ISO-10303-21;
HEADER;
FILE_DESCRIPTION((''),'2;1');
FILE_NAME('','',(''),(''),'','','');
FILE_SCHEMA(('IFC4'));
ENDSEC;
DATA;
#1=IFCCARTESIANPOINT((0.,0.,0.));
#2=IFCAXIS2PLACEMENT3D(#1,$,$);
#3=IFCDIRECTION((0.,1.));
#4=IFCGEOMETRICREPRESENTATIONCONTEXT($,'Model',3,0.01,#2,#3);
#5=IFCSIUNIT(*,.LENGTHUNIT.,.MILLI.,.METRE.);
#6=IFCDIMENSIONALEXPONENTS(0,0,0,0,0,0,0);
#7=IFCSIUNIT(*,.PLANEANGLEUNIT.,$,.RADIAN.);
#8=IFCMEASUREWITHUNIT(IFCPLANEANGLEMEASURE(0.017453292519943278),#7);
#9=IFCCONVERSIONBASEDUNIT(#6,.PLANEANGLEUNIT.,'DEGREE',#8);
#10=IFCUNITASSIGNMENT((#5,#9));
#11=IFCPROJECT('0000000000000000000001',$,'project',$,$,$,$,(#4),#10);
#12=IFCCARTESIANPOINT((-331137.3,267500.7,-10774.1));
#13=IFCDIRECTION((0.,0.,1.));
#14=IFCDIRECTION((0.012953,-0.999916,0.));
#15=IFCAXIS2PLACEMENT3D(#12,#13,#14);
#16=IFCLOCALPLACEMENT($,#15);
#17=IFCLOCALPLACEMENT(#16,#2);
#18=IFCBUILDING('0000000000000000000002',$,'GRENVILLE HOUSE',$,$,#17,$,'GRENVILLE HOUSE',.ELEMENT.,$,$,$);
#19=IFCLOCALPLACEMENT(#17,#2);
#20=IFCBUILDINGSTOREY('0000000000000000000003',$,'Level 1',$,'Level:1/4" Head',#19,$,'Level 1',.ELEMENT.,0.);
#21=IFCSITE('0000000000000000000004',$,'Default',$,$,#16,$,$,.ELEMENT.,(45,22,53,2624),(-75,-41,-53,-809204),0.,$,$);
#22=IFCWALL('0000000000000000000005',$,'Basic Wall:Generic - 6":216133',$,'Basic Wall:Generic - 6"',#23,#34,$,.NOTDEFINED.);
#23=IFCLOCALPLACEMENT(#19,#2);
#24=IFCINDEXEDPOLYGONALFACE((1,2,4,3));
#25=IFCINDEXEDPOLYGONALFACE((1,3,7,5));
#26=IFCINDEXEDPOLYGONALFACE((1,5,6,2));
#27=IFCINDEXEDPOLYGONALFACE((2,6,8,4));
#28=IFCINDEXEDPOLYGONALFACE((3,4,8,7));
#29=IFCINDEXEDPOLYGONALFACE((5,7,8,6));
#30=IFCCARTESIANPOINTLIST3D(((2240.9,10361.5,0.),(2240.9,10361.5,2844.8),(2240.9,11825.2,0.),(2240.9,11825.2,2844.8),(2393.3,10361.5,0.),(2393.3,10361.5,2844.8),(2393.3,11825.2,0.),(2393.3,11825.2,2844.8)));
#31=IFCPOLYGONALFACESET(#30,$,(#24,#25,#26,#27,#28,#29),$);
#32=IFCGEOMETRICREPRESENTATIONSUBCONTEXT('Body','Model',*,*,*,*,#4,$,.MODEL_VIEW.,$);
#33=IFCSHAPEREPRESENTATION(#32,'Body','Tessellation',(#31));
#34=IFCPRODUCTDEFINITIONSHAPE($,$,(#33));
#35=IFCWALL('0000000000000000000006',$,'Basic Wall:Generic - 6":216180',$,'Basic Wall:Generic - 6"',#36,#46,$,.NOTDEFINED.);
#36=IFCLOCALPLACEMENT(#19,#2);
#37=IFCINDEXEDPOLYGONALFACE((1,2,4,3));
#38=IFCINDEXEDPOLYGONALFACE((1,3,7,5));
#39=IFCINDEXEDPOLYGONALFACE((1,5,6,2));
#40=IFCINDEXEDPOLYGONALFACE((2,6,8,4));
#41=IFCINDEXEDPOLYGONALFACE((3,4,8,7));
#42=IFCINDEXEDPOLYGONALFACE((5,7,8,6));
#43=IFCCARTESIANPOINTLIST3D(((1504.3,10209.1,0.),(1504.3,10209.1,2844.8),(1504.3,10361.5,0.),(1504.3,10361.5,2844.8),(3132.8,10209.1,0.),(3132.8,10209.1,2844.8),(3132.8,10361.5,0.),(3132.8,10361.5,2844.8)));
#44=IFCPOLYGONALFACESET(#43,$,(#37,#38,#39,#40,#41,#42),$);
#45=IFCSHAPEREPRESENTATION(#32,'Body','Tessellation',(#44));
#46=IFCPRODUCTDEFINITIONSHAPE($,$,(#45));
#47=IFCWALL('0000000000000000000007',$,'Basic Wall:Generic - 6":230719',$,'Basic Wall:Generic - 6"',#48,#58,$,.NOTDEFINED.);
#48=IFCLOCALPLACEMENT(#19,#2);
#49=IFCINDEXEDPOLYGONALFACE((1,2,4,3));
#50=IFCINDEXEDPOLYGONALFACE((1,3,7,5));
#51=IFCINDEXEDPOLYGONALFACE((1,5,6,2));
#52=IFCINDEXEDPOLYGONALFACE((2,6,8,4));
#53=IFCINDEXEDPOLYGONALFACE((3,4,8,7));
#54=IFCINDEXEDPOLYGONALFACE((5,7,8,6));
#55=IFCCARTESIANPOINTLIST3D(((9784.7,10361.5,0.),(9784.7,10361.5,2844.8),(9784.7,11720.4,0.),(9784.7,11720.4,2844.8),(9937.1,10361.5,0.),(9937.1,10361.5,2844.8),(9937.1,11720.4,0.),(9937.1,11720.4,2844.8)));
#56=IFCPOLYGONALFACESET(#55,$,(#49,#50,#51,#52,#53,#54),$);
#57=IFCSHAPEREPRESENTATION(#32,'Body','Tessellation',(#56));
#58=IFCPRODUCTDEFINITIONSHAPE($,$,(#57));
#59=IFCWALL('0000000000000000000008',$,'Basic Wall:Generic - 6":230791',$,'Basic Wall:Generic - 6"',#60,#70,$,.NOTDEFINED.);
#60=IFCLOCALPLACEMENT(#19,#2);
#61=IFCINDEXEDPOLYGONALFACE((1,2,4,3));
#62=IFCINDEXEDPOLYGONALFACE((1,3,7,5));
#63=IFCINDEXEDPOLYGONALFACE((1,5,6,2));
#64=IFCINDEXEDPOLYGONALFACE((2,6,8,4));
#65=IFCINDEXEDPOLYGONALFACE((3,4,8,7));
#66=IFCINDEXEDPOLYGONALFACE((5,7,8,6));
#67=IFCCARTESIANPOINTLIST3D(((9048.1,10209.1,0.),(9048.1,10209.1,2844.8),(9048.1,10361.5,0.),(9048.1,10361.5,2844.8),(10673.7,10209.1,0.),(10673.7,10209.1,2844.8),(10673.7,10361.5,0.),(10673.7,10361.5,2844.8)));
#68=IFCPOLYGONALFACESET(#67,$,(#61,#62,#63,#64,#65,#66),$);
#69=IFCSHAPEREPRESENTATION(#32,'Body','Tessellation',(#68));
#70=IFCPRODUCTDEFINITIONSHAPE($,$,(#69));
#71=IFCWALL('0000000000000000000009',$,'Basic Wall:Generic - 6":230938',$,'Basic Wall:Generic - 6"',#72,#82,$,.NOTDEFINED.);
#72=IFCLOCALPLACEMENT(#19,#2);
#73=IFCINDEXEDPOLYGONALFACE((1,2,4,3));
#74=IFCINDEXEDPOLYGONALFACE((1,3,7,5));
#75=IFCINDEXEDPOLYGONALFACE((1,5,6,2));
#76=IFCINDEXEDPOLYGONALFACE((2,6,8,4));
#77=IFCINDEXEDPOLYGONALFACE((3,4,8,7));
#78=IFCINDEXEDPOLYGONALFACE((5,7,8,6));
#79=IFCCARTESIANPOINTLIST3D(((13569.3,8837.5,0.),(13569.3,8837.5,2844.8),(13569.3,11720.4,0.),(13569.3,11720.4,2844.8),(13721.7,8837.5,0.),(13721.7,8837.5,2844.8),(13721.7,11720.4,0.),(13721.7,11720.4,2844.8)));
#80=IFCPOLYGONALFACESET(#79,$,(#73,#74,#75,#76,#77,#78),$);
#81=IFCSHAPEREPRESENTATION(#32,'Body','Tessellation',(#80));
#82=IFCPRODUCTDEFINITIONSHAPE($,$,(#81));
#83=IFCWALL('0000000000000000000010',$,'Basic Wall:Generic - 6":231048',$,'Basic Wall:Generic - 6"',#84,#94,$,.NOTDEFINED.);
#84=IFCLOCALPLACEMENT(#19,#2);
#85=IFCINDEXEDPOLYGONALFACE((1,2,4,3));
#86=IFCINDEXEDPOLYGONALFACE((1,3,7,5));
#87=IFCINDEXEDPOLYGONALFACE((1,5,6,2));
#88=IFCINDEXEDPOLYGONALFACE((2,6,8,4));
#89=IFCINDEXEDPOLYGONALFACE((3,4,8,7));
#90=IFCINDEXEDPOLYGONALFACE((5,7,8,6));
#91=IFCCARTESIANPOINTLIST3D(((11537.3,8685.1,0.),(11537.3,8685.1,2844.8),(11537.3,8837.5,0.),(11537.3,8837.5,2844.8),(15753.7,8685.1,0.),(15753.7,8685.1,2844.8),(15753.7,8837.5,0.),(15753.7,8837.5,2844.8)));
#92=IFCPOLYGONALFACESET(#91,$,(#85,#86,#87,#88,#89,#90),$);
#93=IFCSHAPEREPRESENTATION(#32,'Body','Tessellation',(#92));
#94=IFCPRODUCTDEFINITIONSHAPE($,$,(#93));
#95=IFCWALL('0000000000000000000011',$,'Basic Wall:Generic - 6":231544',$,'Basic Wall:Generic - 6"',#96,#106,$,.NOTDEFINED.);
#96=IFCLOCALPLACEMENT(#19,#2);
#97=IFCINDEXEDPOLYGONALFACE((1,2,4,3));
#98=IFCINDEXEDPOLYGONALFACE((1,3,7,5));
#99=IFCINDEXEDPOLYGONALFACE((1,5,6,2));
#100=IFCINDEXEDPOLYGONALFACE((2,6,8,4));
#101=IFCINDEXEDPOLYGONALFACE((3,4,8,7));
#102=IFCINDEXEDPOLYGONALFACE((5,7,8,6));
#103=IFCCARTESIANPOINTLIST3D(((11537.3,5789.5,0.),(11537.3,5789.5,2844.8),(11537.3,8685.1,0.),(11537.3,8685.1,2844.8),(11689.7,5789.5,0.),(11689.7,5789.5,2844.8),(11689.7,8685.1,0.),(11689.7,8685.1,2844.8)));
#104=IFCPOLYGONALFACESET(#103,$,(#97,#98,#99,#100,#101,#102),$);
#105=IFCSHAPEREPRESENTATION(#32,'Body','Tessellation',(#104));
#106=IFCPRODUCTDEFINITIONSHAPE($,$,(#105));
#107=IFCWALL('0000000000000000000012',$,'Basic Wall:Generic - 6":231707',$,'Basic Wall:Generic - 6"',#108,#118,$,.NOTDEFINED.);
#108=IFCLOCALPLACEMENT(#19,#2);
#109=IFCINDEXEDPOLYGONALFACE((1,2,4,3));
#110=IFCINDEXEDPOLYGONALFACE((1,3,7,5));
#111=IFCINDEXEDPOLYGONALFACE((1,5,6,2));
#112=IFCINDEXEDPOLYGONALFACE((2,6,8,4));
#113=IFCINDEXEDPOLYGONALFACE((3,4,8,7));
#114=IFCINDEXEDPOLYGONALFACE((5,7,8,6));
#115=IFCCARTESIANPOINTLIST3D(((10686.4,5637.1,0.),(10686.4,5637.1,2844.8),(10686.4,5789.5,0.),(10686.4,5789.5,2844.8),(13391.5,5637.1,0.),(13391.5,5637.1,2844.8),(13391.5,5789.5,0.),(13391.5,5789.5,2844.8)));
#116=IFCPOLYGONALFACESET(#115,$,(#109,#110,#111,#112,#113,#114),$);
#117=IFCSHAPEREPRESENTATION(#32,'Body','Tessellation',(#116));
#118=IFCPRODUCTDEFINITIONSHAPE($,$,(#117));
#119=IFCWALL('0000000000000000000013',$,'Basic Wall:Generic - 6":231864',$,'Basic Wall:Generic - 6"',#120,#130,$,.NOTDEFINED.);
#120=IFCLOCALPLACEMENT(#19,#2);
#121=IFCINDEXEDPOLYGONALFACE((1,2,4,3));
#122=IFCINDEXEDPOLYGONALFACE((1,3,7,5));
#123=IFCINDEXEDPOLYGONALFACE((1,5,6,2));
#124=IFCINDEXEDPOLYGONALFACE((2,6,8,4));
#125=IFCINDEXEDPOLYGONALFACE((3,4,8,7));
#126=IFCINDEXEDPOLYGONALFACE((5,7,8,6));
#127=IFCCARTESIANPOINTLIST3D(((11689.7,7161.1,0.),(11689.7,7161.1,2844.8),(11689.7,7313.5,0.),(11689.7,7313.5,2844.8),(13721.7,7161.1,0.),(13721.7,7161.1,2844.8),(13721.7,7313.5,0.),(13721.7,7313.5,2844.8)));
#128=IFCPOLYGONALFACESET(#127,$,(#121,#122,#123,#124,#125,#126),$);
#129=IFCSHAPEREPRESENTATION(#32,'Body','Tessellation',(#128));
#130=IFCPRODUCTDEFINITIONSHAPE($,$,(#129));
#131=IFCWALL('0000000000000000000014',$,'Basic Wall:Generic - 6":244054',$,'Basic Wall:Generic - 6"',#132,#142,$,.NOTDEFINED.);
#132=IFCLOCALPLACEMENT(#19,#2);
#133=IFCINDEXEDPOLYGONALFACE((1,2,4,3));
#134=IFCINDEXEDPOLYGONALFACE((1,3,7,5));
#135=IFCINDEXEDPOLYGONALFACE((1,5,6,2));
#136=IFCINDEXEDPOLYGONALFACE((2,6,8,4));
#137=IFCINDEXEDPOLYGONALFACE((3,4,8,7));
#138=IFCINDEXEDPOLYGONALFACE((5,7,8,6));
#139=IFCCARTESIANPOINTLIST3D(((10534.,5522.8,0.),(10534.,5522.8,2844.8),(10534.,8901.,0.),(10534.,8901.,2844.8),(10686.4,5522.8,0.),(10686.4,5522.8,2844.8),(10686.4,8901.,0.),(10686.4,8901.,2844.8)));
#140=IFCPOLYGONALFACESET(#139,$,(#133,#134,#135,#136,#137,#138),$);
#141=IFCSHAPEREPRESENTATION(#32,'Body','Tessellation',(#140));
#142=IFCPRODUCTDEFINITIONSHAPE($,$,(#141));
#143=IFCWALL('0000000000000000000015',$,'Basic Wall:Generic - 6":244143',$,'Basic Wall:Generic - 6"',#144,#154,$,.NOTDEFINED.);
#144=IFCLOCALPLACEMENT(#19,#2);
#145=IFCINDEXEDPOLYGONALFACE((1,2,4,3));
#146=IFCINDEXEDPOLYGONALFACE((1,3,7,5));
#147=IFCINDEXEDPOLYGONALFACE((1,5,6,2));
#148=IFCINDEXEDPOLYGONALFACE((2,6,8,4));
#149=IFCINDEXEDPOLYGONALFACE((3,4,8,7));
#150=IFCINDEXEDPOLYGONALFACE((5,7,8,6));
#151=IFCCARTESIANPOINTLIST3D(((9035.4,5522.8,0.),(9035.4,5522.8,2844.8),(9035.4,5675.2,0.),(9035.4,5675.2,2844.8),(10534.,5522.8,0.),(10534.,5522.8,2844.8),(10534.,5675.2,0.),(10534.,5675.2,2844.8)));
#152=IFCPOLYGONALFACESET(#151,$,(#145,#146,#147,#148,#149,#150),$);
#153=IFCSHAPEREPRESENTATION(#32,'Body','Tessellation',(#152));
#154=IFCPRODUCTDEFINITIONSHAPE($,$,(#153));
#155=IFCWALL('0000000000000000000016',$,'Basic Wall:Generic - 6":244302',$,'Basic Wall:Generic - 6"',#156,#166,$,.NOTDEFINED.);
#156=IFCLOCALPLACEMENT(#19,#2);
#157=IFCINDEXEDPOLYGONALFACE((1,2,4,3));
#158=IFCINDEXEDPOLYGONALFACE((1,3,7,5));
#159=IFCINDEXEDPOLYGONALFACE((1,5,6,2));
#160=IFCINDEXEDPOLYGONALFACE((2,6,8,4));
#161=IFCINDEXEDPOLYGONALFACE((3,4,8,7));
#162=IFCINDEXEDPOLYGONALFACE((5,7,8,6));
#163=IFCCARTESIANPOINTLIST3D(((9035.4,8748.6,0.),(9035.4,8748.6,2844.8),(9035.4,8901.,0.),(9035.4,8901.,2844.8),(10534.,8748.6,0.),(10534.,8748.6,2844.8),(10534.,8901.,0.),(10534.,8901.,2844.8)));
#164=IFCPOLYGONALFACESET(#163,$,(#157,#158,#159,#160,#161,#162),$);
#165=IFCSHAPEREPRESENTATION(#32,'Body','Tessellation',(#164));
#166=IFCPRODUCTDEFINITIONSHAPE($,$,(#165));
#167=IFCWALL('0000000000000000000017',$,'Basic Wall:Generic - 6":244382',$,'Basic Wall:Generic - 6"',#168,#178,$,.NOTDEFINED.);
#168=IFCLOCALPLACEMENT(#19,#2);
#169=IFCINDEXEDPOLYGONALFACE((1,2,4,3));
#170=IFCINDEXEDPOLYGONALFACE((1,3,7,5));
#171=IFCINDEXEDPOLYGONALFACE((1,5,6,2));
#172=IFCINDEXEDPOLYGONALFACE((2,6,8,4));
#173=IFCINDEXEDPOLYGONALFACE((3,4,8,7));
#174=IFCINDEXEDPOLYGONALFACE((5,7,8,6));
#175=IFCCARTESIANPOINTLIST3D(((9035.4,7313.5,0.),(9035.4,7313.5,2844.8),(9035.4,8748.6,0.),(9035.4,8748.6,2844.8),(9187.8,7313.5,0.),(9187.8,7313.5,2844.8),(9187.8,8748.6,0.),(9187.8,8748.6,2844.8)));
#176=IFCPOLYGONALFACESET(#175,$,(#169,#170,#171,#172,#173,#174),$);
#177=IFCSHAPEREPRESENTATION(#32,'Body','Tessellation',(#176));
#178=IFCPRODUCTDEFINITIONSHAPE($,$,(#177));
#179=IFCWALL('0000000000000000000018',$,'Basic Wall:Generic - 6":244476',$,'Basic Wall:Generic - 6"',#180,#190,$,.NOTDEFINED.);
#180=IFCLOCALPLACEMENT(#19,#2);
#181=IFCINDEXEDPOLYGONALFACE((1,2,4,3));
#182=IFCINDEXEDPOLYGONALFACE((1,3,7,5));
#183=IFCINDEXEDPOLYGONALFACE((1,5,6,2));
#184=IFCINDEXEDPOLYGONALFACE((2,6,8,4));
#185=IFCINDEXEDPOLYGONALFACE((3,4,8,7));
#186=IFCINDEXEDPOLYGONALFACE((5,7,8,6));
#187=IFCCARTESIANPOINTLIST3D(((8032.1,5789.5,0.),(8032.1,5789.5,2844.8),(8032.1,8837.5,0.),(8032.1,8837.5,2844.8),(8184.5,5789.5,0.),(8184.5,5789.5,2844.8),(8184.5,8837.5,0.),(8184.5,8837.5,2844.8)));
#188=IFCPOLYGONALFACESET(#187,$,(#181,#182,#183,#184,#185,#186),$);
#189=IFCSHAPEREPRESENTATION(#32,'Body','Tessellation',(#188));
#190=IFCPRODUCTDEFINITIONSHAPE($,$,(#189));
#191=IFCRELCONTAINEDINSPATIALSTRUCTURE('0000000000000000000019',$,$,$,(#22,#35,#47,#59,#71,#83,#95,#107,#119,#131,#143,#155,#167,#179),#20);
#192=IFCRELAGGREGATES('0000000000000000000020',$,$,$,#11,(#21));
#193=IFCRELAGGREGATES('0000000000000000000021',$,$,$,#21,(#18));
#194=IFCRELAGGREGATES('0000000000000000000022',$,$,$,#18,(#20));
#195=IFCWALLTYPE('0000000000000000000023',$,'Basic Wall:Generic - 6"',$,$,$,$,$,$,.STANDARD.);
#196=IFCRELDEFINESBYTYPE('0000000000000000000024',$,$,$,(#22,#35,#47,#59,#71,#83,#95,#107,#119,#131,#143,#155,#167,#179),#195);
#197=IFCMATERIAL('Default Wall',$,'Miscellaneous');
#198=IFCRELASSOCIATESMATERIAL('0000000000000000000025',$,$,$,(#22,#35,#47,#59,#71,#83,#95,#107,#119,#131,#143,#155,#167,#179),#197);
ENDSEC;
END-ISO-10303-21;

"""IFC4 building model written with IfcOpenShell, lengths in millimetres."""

from ifc_helpers import new_model, entity, si_unit, converted_unit, direction, frame, origin, place, context, subcontext, project, spatial, indexed_curve, outline, extrude, material, type_object, element, save


model = new_model("IFC4")

# Units and contexts
model_context = context("Model", 3, precision=0.01, world=origin(), true_north=direction((0.0, 1.0)))
body_context = subcontext(model_context, "Body", "Model", "MODEL_VIEW")
ifc_project = project(units=[si_unit("LENGTHUNIT", "METRE", prefix="MILLI"), converted_unit("PLANEANGLEUNIT", "DEGREE", entity("IfcPlaneAngleMeasure", 0.017453292519943278), si_unit("PLANEANGLEUNIT", "RADIAN"), dimensions=[0, 0, 0, 0, 0, 0, 0])], contexts=[model_context])

# Site, building, storey
site_placement = place(None, frame((-331137.3, 267500.7, -10774.1), z_axis=(0.0, 0.0, 1.0), x_axis=(0.012953, -0.999916, 0.0)))
site = spatial("IfcSite", under=ifc_project, at=site_placement, Name="Default", CompositionType="ELEMENT", RefLatitude=(45, 22, 53, 2624), RefLongitude=(-75, -41, -53, -809204), RefElevation=0.0)
building_placement = place(site_placement, origin())
building = spatial("IfcBuilding", under=site, at=building_placement, Name="GRENVILLE HOUSE", LongName="GRENVILLE HOUSE", CompositionType="ELEMENT")
storey_placement = place(building_placement, origin())
storey = spatial("IfcBuildingStorey", under=building, at=storey_placement, Name="Level 1", ObjectType="Level:1/4\" Head", LongName="Level 1", CompositionType="ELEMENT", Elevation=0.0)

# Walls
ifc_material = material(Name="Default Wall", Category="Miscellaneous")
wall_type_1 = type_object("IfcWallType", Name="Basic Wall:Generic - 6\"", PredefinedType="STANDARD")
wall_1_placement = place(storey_placement, frame((2317.1, 11825.2, 0.0), z_axis=(0.0, 0.0, 1.0), x_axis=(0.0, -1.0, 0.0)))
element("IfcWall", 1, at=wall_1_placement, inside=storey, type_object=wall_type_1, material=ifc_material, Name="Basic Wall:Generic - 6\":216133", ObjectType="Basic Wall:Generic - 6\"", PredefinedType="NOTDEFINED", context=body_context, shape_type="SweptSolid", body=[
    extrude(outline(indexed_curve([(1463.7, 76.2), (0.0, 76.2), (0.0, -76.2), (1463.7, -76.2), (1463.7, 76.2)], self_intersect=False)), origin(), (0.0, 0.0, 1.0), 2844.8),
])
wall_2_placement = place(storey_placement, frame((3132.8, 10285.3, 0.0), z_axis=(0.0, 0.0, 1.0), x_axis=(-1.0, 0.0, 0.0)))
element("IfcWall", 2, at=wall_2_placement, inside=storey, type_object=wall_type_1, material=ifc_material, Name="Basic Wall:Generic - 6\":216180", ObjectType="Basic Wall:Generic - 6\"", PredefinedType="NOTDEFINED", context=body_context, shape_type="SweptSolid", body=[
    extrude(outline(indexed_curve([(1628.5, 76.2), (0.0, 76.2), (0.0, -76.2), (1628.5, -76.2), (1628.5, 76.2)], self_intersect=False)), origin(), (0.0, 0.0, 1.0), 2844.8),
])
wall_3_placement = place(storey_placement, frame((9860.9, 11720.4, 0.0), z_axis=(0.0, 0.0, 1.0), x_axis=(0.0, -1.0, 0.0)))
element("IfcWall", 3, at=wall_3_placement, inside=storey, type_object=wall_type_1, material=ifc_material, Name="Basic Wall:Generic - 6\":230719", ObjectType="Basic Wall:Generic - 6\"", PredefinedType="NOTDEFINED", context=body_context, shape_type="SweptSolid", body=[
    extrude(outline(indexed_curve([(1358.9, 76.2), (0.0, 76.2), (0.0, -76.2), (1358.9, -76.2), (1358.9, 76.2)], self_intersect=False)), origin(), (0.0, 0.0, 1.0), 2844.8),
])
wall_4_placement = place(storey_placement, frame((9048.1, 10285.3, 0.0)))
element("IfcWall", 4, at=wall_4_placement, inside=storey, type_object=wall_type_1, material=ifc_material, Name="Basic Wall:Generic - 6\":230791", ObjectType="Basic Wall:Generic - 6\"", PredefinedType="NOTDEFINED", context=body_context, shape_type="SweptSolid", body=[
    extrude(outline(indexed_curve([(1625.6, 76.2), (0.0, 76.2), (0.0, -76.2), (1625.6, -76.2), (1625.6, 76.2)], self_intersect=False)), origin(), (0.0, 0.0, 1.0), 2844.8),
])
wall_5_placement = place(storey_placement, frame((13645.5, 11720.4, 0.0), z_axis=(0.0, 0.0, 1.0), x_axis=(0.0, -1.0, 0.0)))
element("IfcWall", 5, at=wall_5_placement, inside=storey, type_object=wall_type_1, material=ifc_material, Name="Basic Wall:Generic - 6\":230938", ObjectType="Basic Wall:Generic - 6\"", PredefinedType="NOTDEFINED", context=body_context, shape_type="SweptSolid", body=[
    extrude(outline(indexed_curve([(2882.9, 76.2), (0.0, 76.2), (0.0, -76.2), (2882.9, -76.2), (2882.9, 76.2)], self_intersect=False)), origin(), (0.0, 0.0, 1.0), 2844.8),
])
wall_6_placement = place(storey_placement, frame((11537.3, 8761.3, 0.0)))
element("IfcWall", 6, at=wall_6_placement, inside=storey, type_object=wall_type_1, material=ifc_material, Name="Basic Wall:Generic - 6\":231048", ObjectType="Basic Wall:Generic - 6\"", PredefinedType="NOTDEFINED", context=body_context, shape_type="SweptSolid", body=[
    extrude(outline(indexed_curve([(4216.4, 76.2), (0.0, 76.2), (0.0, -76.2), (4216.4, -76.2), (4216.4, 76.2)], self_intersect=False)), origin(), (0.0, 0.0, 1.0), 2844.8),
])
wall_7_placement = place(storey_placement, frame((11613.5, 8685.1, 0.0), z_axis=(0.0, 0.0, 1.0), x_axis=(0.0, -1.0, 0.0)))
element("IfcWall", 7, at=wall_7_placement, inside=storey, type_object=wall_type_1, material=ifc_material, Name="Basic Wall:Generic - 6\":231544", ObjectType="Basic Wall:Generic - 6\"", PredefinedType="NOTDEFINED", context=body_context, shape_type="SweptSolid", body=[
    extrude(outline(indexed_curve([(2895.6, 76.2), (0.0, 76.2), (0.0, -76.2), (2895.6, -76.2), (2895.6, 76.2)], self_intersect=False)), origin(), (0.0, 0.0, 1.0), 2844.8),
])
wall_8_placement = place(storey_placement, frame((13391.5, 5713.3, 0.0), z_axis=(0.0, 0.0, 1.0), x_axis=(-1.0, 0.0, 0.0)))
element("IfcWall", 8, at=wall_8_placement, inside=storey, type_object=wall_type_1, material=ifc_material, Name="Basic Wall:Generic - 6\":231707", ObjectType="Basic Wall:Generic - 6\"", PredefinedType="NOTDEFINED", context=body_context, shape_type="SweptSolid", body=[
    extrude(outline(indexed_curve([(2705.1, 76.2), (0.0, 76.2), (0.0, -76.2), (2705.1, -76.2), (2705.1, 76.2)], self_intersect=False)), origin(), (0.0, 0.0, 1.0), 2844.8),
])
wall_9_placement = place(storey_placement, frame((11689.7, 7237.3, 0.0)))
element("IfcWall", 9, at=wall_9_placement, inside=storey, type_object=wall_type_1, material=ifc_material, Name="Basic Wall:Generic - 6\":231864", ObjectType="Basic Wall:Generic - 6\"", PredefinedType="NOTDEFINED", context=body_context, shape_type="SweptSolid", body=[
    extrude(outline(indexed_curve([(2032.0, 76.2), (0.0, 76.2), (0.0, -76.2), (2032.0, -76.2), (2032.0, 76.2)], self_intersect=False)), origin(), (0.0, 0.0, 1.0), 2844.8),
])
wall_10_placement = place(storey_placement, frame((10610.2, 5522.8, 0.0), z_axis=(0.0, 0.0, 1.0), x_axis=(0.0, 1.0, 0.0)))
element("IfcWall", 10, at=wall_10_placement, inside=storey, type_object=wall_type_1, material=ifc_material, Name="Basic Wall:Generic - 6\":244054", ObjectType="Basic Wall:Generic - 6\"", PredefinedType="NOTDEFINED", context=body_context, shape_type="SweptSolid", body=[
    extrude(outline(indexed_curve([(3378.2, 76.2), (0.0, 76.2), (0.0, -76.2), (3378.2, -76.2), (3378.2, 76.2)], self_intersect=False)), origin(), (0.0, 0.0, 1.0), 2844.8),
])
wall_11_placement = place(storey_placement, frame((10534.0, 5599.0, 0.0), z_axis=(0.0, 0.0, 1.0), x_axis=(-1.0, 0.0, 0.0)))
element("IfcWall", 11, at=wall_11_placement, inside=storey, type_object=wall_type_1, material=ifc_material, Name="Basic Wall:Generic - 6\":244143", ObjectType="Basic Wall:Generic - 6\"", PredefinedType="NOTDEFINED", context=body_context, shape_type="SweptSolid", body=[
    extrude(outline(indexed_curve([(1498.6, 76.2), (0.0, 76.2), (0.0, -76.2), (1498.6, -76.2), (1498.6, 76.2)], self_intersect=False)), origin(), (0.0, 0.0, 1.0), 2844.8),
])
wall_12_placement = place(storey_placement, frame((10534.0, 8824.8, 0.0), z_axis=(0.0, 0.0, 1.0), x_axis=(-1.0, 0.0, 0.0)))
element("IfcWall", 12, at=wall_12_placement, inside=storey, type_object=wall_type_1, material=ifc_material, Name="Basic Wall:Generic - 6\":244302", ObjectType="Basic Wall:Generic - 6\"", PredefinedType="NOTDEFINED", context=body_context, shape_type="SweptSolid", body=[
    extrude(outline(indexed_curve([(1498.6, 76.2), (0.0, 76.2), (0.0, -76.2), (1498.6, -76.2), (1498.6, 76.2)], self_intersect=False)), origin(), (0.0, 0.0, 1.0), 2844.8),
])
wall_13_placement = place(storey_placement, frame((9111.6, 8748.6, 0.0), z_axis=(0.0, 0.0, 1.0), x_axis=(0.0, -1.0, 0.0)))
element("IfcWall", 13, at=wall_13_placement, inside=storey, type_object=wall_type_1, material=ifc_material, Name="Basic Wall:Generic - 6\":244382", ObjectType="Basic Wall:Generic - 6\"", PredefinedType="NOTDEFINED", context=body_context, shape_type="SweptSolid", body=[
    extrude(outline(indexed_curve([(1435.1, 76.2), (0.0, 76.2), (0.0, -76.2), (1435.1, -76.2), (1435.1, 76.2)], self_intersect=False)), origin(), (0.0, 0.0, 1.0), 2844.8),
])
wall_14_placement = place(storey_placement, frame((8108.3, 5789.5, 0.0), z_axis=(0.0, 0.0, 1.0), x_axis=(0.0, 1.0, 0.0)))
element("IfcWall", 14, at=wall_14_placement, inside=storey, type_object=wall_type_1, material=ifc_material, Name="Basic Wall:Generic - 6\":244476", ObjectType="Basic Wall:Generic - 6\"", PredefinedType="NOTDEFINED", context=body_context, shape_type="SweptSolid", body=[
    extrude(outline(indexed_curve([(3048.0, 76.2), (0.0, 76.2), (0.0, -76.2), (3048.0, -76.2), (3048.0, 76.2)], self_intersect=False)), origin(), (0.0, 0.0, 1.0), 2844.8),
])

save(model, "model.ifc")
